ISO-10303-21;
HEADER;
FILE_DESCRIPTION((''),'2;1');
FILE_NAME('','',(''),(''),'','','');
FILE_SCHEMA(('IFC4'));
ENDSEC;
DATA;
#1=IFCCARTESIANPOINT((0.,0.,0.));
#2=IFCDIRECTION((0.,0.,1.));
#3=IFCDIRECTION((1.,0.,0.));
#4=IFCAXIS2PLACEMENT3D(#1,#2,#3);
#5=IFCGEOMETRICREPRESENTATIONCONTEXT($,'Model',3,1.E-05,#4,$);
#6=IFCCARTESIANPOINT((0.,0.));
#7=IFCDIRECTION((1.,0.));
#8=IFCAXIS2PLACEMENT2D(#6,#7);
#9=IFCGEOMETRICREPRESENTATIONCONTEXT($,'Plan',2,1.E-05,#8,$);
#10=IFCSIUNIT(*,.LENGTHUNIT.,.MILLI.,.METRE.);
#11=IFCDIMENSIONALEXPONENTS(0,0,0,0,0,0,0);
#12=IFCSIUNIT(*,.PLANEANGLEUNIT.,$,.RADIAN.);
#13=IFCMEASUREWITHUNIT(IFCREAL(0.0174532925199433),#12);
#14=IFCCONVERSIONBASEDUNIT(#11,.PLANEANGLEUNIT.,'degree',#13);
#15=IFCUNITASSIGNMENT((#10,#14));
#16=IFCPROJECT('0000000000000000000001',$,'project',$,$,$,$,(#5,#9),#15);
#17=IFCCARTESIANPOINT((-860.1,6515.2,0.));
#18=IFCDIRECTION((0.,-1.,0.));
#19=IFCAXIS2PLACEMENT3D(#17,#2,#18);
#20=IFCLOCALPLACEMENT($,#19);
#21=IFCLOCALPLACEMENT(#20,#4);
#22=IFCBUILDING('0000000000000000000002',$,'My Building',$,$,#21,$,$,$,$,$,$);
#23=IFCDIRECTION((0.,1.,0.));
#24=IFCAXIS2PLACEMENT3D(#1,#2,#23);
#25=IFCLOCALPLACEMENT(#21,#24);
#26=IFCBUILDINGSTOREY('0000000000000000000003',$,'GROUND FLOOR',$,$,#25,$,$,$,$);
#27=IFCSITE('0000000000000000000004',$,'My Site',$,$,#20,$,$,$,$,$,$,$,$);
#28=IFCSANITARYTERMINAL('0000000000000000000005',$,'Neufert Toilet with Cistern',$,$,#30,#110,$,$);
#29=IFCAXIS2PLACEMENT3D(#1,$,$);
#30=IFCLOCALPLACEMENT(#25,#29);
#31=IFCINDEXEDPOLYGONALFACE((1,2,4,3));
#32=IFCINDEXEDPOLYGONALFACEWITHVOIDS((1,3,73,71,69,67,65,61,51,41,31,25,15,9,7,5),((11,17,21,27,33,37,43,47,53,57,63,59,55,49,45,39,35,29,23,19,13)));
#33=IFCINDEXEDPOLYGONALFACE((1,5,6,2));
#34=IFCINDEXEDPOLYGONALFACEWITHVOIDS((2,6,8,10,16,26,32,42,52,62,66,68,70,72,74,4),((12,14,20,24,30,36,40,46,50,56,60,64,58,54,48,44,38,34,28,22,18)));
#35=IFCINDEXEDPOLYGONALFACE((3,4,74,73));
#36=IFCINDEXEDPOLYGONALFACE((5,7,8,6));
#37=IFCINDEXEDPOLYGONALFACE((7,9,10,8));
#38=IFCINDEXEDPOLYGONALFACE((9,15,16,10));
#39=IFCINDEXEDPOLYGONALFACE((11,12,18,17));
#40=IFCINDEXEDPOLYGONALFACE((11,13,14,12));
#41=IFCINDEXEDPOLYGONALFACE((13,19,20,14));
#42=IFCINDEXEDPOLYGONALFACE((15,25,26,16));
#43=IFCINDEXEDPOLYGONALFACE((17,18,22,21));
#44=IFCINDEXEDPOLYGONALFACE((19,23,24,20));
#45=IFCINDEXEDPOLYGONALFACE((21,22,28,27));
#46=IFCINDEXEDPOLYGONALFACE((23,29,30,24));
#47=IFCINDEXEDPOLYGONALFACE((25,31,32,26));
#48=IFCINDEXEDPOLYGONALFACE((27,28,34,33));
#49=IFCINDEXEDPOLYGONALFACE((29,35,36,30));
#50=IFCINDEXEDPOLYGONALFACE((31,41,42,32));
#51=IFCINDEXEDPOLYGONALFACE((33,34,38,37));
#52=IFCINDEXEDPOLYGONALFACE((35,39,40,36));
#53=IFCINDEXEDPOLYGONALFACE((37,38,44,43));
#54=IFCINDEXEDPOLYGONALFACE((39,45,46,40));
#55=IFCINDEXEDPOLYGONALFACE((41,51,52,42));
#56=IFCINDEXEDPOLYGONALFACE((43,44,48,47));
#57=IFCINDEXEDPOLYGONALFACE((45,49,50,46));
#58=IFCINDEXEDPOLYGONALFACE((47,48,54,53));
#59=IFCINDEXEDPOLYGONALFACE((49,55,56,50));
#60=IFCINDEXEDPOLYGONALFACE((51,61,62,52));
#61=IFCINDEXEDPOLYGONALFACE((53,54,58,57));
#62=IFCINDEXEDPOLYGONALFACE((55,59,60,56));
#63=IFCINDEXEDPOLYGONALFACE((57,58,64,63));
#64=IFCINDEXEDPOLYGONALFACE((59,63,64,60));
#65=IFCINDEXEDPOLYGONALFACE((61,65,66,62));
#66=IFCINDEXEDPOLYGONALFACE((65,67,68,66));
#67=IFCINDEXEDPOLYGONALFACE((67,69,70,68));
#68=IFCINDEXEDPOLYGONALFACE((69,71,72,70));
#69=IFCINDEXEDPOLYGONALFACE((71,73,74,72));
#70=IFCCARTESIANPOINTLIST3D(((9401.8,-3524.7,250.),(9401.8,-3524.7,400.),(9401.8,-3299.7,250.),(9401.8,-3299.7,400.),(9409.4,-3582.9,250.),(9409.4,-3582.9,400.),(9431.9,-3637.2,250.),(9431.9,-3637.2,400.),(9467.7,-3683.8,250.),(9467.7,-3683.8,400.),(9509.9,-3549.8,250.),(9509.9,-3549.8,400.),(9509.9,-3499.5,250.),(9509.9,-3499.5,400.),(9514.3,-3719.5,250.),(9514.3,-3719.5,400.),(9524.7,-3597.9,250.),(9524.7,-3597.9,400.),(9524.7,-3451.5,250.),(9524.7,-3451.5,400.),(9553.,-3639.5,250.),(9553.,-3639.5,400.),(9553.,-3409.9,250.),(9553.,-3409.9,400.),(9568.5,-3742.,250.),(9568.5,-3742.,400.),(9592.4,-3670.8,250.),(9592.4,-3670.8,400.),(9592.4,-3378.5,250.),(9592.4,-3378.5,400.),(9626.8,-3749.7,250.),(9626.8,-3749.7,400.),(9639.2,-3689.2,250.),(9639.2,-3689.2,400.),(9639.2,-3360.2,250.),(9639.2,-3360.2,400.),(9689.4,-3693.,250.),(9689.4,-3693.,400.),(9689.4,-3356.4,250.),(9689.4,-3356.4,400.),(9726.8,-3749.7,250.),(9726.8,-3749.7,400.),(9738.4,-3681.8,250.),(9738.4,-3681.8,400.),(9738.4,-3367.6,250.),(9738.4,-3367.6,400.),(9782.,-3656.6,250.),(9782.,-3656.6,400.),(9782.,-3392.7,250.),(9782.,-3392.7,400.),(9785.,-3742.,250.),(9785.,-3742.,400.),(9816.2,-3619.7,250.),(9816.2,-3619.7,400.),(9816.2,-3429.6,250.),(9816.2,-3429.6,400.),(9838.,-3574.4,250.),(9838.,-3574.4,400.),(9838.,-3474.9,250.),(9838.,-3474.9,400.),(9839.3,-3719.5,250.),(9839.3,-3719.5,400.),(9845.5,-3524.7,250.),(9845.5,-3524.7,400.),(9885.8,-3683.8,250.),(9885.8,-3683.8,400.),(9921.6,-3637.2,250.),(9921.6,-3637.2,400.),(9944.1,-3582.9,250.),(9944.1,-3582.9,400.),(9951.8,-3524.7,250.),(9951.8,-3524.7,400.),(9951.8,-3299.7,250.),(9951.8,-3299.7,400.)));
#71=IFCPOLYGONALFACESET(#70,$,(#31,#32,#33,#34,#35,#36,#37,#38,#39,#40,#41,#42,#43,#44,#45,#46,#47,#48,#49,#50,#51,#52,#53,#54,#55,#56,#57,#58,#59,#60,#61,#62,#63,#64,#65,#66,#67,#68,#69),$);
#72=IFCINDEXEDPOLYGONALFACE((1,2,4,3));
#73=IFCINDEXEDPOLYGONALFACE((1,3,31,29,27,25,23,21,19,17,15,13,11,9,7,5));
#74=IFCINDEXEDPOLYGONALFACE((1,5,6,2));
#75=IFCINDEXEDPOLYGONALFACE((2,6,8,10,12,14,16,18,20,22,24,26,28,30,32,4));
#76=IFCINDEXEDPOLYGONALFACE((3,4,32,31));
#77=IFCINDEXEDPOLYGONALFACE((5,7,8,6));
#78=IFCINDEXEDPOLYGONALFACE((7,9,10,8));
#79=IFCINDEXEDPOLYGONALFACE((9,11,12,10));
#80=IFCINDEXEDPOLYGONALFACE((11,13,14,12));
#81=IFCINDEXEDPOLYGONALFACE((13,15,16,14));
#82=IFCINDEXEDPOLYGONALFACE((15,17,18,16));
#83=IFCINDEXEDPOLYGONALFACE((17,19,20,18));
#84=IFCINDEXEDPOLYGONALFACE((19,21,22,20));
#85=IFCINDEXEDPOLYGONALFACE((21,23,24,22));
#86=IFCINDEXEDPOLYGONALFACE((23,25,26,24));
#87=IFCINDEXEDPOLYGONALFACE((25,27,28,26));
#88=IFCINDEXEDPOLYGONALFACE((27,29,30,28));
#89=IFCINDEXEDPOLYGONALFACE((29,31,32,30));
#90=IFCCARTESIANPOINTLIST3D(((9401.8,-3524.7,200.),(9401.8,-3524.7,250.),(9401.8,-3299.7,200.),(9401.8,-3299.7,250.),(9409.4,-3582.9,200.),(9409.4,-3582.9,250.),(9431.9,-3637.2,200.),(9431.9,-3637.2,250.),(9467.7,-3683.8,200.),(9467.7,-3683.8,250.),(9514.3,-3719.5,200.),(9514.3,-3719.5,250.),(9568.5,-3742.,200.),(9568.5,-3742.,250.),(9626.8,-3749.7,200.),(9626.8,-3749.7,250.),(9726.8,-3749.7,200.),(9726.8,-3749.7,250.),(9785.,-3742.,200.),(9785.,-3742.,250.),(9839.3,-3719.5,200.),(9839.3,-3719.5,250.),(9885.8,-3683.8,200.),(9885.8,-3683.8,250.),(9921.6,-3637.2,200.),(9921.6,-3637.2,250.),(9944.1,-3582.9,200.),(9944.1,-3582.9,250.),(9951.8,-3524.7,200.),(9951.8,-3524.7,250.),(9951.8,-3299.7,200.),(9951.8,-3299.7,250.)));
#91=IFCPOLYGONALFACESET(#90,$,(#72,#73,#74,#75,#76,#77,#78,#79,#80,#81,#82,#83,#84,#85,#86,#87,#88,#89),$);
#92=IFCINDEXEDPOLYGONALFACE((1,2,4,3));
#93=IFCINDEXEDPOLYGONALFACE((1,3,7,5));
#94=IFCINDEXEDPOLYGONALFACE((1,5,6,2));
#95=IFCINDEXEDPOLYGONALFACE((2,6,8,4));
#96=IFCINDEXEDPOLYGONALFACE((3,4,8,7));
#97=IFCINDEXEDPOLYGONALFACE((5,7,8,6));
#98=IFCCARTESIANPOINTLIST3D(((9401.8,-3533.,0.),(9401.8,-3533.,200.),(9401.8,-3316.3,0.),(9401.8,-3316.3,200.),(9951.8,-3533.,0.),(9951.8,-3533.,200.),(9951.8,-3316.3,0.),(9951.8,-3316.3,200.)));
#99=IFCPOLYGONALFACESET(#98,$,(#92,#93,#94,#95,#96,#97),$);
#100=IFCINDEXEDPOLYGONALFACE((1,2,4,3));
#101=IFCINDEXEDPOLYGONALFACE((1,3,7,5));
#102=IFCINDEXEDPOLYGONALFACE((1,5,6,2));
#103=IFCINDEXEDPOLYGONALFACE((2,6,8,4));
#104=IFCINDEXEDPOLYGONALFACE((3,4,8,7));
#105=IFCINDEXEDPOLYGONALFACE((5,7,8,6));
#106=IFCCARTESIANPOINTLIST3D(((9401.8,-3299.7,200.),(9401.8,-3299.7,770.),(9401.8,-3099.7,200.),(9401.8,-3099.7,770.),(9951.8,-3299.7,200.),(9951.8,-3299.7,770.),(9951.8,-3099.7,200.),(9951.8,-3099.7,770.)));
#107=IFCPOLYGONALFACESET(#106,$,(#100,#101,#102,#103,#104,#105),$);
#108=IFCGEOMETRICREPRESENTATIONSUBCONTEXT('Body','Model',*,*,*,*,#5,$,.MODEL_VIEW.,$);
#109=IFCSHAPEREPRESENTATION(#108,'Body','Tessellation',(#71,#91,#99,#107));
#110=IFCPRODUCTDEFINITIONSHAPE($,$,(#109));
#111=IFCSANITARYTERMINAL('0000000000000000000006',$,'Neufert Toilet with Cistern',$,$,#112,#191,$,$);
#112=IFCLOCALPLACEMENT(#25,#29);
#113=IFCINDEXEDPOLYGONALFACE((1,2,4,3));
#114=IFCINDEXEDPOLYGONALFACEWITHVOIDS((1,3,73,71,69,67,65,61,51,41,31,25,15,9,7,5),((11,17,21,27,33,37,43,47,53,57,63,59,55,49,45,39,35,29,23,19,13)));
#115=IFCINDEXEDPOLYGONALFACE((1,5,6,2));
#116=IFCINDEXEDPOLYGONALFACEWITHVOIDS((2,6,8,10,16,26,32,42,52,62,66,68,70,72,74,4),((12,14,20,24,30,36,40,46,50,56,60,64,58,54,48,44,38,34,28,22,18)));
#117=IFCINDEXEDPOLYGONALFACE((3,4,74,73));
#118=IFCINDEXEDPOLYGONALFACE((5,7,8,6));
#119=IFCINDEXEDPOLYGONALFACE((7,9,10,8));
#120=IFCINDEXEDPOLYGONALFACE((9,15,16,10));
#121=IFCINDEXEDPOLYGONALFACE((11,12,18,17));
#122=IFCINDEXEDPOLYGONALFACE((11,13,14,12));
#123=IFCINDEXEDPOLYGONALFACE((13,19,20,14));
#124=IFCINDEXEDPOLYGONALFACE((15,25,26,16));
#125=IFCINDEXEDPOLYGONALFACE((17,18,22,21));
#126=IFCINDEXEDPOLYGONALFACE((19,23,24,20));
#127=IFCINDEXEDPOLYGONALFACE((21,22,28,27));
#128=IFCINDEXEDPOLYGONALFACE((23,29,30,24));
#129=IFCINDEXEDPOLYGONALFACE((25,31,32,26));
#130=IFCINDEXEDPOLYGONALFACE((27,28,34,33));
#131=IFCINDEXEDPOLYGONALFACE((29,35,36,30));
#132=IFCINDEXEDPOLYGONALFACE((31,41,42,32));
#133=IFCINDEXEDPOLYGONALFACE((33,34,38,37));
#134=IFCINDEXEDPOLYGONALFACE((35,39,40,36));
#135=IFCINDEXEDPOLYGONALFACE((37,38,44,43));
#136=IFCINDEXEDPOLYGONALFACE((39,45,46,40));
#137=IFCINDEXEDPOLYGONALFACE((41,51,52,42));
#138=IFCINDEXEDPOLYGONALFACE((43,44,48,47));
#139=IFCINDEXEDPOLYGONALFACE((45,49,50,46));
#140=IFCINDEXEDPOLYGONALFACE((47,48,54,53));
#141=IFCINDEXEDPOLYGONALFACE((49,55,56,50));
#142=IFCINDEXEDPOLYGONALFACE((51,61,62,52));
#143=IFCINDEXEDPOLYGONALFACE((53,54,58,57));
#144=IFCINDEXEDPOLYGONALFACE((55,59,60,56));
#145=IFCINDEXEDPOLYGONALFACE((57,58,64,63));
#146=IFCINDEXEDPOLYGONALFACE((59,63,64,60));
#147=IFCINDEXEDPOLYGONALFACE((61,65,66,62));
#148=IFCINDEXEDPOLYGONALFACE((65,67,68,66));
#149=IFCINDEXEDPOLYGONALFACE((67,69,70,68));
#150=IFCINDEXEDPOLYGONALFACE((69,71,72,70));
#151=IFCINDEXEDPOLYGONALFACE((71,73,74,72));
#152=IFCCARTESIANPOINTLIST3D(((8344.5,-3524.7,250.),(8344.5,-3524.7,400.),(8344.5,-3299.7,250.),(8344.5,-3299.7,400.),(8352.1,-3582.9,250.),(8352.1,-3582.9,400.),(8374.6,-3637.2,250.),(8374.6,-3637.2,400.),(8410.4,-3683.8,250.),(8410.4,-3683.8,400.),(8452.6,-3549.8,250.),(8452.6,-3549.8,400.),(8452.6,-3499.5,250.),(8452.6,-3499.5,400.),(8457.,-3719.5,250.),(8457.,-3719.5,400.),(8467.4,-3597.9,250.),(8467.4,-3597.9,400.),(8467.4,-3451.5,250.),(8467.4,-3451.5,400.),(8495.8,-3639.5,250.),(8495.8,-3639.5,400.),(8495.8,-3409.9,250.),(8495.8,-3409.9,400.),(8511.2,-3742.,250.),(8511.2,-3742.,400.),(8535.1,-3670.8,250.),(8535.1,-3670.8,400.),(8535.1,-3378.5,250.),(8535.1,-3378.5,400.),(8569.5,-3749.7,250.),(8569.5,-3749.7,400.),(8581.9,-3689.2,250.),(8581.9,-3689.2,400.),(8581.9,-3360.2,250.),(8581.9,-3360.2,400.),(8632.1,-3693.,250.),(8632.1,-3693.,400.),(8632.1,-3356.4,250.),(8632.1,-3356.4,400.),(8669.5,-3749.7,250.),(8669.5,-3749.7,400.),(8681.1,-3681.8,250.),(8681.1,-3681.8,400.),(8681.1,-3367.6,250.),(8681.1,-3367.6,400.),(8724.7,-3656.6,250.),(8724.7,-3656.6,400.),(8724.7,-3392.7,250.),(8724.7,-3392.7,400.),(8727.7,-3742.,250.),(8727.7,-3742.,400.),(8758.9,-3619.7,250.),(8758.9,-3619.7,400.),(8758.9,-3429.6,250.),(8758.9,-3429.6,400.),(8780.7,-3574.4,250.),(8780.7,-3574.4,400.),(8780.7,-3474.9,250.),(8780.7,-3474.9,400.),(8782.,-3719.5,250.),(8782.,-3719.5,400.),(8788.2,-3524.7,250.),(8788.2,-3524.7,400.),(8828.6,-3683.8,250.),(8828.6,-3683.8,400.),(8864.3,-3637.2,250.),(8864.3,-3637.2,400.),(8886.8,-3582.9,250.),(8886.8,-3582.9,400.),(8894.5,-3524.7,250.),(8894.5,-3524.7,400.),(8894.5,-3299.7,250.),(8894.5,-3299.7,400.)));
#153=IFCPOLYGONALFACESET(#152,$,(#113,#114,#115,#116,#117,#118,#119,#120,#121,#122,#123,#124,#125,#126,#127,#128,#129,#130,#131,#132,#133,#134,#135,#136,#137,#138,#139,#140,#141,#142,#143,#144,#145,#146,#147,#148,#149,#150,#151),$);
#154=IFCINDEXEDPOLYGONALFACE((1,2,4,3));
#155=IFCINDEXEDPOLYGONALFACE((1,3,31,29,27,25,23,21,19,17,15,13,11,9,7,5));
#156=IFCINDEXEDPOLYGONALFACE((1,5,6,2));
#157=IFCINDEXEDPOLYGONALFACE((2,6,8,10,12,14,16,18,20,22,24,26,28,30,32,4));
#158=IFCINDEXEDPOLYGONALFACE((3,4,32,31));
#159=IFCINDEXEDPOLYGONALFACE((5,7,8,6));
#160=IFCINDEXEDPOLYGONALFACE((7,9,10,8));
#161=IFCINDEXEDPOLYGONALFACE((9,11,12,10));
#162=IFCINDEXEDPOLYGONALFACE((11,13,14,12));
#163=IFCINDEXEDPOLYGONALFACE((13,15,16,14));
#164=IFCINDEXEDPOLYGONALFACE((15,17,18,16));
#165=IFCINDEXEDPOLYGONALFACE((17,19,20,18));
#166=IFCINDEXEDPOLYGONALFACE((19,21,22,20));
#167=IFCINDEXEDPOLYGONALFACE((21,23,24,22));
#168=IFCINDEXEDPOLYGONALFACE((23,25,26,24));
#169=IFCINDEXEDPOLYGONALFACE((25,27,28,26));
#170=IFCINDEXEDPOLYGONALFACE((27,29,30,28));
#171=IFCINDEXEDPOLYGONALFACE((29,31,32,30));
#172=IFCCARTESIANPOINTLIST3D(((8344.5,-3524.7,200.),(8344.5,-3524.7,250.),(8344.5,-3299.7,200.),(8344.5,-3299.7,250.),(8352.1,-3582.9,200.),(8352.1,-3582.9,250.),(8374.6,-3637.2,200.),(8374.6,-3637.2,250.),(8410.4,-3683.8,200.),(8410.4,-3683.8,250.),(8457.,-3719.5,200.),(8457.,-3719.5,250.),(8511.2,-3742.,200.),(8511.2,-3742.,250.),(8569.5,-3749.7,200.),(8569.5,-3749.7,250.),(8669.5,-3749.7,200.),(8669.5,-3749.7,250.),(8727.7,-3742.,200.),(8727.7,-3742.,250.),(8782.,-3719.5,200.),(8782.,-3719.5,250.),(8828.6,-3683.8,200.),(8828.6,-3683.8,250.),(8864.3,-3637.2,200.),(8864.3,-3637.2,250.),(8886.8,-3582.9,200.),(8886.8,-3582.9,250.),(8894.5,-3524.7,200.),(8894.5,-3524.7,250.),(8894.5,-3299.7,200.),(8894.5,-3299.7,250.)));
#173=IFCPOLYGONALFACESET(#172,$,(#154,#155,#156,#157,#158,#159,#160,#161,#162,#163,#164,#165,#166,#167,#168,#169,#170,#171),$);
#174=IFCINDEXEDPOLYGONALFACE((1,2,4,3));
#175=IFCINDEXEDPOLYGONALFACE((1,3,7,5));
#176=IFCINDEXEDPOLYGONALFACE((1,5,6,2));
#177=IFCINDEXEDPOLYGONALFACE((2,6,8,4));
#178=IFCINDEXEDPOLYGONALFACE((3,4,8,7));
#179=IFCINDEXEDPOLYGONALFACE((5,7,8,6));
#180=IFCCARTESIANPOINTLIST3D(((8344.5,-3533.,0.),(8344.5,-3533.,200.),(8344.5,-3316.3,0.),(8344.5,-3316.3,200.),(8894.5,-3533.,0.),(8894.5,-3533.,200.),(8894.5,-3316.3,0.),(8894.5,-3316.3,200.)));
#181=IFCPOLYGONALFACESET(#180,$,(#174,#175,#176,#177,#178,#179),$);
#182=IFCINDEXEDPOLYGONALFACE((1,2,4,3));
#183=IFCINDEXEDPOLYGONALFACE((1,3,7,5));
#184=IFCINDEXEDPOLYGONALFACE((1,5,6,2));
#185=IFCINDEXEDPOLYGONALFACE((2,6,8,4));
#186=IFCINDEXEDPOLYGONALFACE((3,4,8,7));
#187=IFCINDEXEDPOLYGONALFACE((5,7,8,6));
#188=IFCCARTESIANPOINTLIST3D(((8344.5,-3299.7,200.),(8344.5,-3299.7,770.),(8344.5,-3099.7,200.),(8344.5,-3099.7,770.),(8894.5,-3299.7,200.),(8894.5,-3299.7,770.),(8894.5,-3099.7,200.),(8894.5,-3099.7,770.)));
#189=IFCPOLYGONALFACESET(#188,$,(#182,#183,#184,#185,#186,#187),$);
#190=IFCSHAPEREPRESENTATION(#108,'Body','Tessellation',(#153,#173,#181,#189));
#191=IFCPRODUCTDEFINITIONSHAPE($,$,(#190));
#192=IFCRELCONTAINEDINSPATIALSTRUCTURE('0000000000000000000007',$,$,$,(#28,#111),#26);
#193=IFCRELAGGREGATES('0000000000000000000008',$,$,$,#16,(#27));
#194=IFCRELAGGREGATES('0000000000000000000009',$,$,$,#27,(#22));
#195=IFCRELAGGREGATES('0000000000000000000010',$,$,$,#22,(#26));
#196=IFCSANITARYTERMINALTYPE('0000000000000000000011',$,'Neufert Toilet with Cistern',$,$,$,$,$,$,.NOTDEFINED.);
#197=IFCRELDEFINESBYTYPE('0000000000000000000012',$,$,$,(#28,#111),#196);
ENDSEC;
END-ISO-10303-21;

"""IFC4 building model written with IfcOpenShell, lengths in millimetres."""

from ifc_helpers import new_model, entity, si_unit, converted_unit, frame, frame_2d, origin_with_axes, origin_2d_with_axis, place, context, subcontext, project, spatial, line, arc, indexed_curve, circle_curve, outline, extrude, shape, source, transform, mapped, type_object, type_shapes, element, save


model = new_model("IFC4")

# Units and contexts
model_context = context("Model", 3, precision=1e-05, world=origin_with_axes())
plan_context = context("Plan", 2, precision=1e-05, world=origin_2d_with_axis())
body_context_1 = subcontext(model_context, "Body", "Model", "MODEL_VIEW")
body_context_2 = subcontext(plan_context, "Body", "Plan", "PLAN_VIEW")
ifc_project = project(units=[si_unit("LENGTHUNIT", "METRE", prefix="MILLI"), converted_unit("PLANEANGLEUNIT", "degree", entity("IfcReal", 0.0174532925199433), si_unit("PLANEANGLEUNIT", "RADIAN"), dimensions=[0, 0, 0, 0, 0, 0, 0])], contexts=[model_context, plan_context])

# Site, building, storey
site_placement = place(None, frame((-860.1, 6515.2, 0.0), z_axis=(0.0, 0.0, 1.0), x_axis=(0.0, -1.0, 0.0)))
site = spatial("IfcSite", under=ifc_project, at=site_placement, Name="My Site")
building_placement = place(site_placement, frame((0.0, 0.0, 0.0), z_axis=(0.0, 0.0, 1.0), x_axis=(1.0, 0.0, 0.0)))
building = spatial("IfcBuilding", under=site, at=building_placement, Name="My Building")
storey_placement = place(building_placement, frame((0.0, 0.0, 0.0), z_axis=(0.0, 0.0, 1.0), x_axis=(0.0, 1.0, 0.0)))
storey = spatial("IfcBuildingStorey", under=building, at=storey_placement, Name="GROUND FLOOR")

# Sanitary terminals
sanitary_terminal_type_1 = type_object("IfcSanitaryTerminalType", Name="Neufert Toilet with Cistern", PredefinedType="NOTDEFINED")
shared_shape_1 = source(origin_with_axes(), body_context_1, "Body", "SweptSolid", [
    extrude(outline(indexed_curve([(-275.0, -200.0), (275.0, -200.0), (275.0, -425.0), (209.1, -584.1), (50.0, -650.0), (-50.0, -650.0), (-209.1, -584.1), (-275.0, -425.0)], segments=[line(1, 2), line(2, 3), arc(3, 4, 5), line(5, 6), arc(6, 7, 8), line(8, 1)]), holes=[circle_curve(frame_2d((0.0, -425.0)), 168.8)]), frame((0.0, 0.0, 250.0), z_axis=(0.0, 0.0, 1.0), x_axis=(1.0, 0.0, 0.0)), (0.0, 0.0, 1.0), 150.0),
    extrude(outline(indexed_curve([(-275.0, -200.0), (275.0, -200.0), (275.0, -425.0), (209.1, -584.1), (50.0, -650.0), (-50.0, -650.0), (-209.1, -584.1), (-275.0, -425.0)], segments=[line(1, 2), line(2, 3), arc(3, 4, 5), line(5, 6), arc(6, 7, 8), line(8, 1)])), frame((0.0, 0.0, 200.0), z_axis=(0.0, 0.0, 1.0), x_axis=(1.0, 0.0, 0.0)), (0.0, 0.0, 1.0), 50.0),
    extrude(outline(indexed_curve([(-275.0, -216.7), (275.0, -216.7), (275.0, -433.3), (-275.0, -433.3)], segments=[line(1, 2), line(2, 3), line(3, 4), line(4, 1)])), origin_with_axes(), (0.0, 0.0, 1.0), 200.0),
    extrude(outline(indexed_curve([(-275.0, 0.0), (275.0, 0.0), (275.0, -200.0), (-275.0, -200.0)], segments=[line(1, 2), line(2, 3), line(3, 4), line(4, 1)])), frame((0.0, 0.0, 200.0), z_axis=(0.0, 0.0, 1.0), x_axis=(1.0, 0.0, 0.0)), (0.0, 0.0, 1.0), 570.0),
])
shared_shape_2 = source(origin_with_axes(), body_context_2, "Body", "Curve2D", [
    entity("IfcIndexedPolyCurve", entity("IfcCartesianPointList2D", [[-275.0, 0.0], [275.0, 0.0], [275.0, -200.0], [-275.0, -200.0]]), [entity("IfcLineIndex", [1, 2]), entity("IfcLineIndex", [2, 3]), entity("IfcLineIndex", [3, 4]), entity("IfcLineIndex", [4, 1])]),
    entity("IfcIndexedPolyCurve", entity("IfcCartesianPointList2D", [[165.0, -200.0], [192.5, -335.0]]), [entity("IfcLineIndex", [1, 2])]),
    entity("IfcTrimmedCurve", entity("IfcEllipse", entity("IfcAxis2Placement2D", entity("IfcCartesianPoint", [0.0, -335.0]), entity("IfcDirection", [1.0, 0.0])), 192.5, 315.0), [entity("IfcCartesianPoint", [-192.5, -335.0])], [entity("IfcCartesianPoint", [192.5, -335.0])], True, "CARTESIAN"),
    entity("IfcIndexedPolyCurve", entity("IfcCartesianPointList2D", [[-165.0, -200.0], [-192.5, -335.0]]), [entity("IfcLineIndex", [1, 2])]),
    entity("IfcEllipse", entity("IfcAxis2Placement2D", entity("IfcCartesianPoint", [0.0, -452.0]), entity("IfcDirection", [1.0, 0.0])), 131.2, 157.5),
    entity("IfcIndexedPolyCurve", entity("IfcCartesianPointList2D", [[-34.4, -452.0], [-34.4, -429.5], [34.4, -429.5], [34.4, -452.0]]), [entity("IfcLineIndex", [1, 2]), entity("IfcLineIndex", [2, 3]), entity("IfcLineIndex", [3, 4])]),
    entity("IfcTrimmedCurve", entity("IfcEllipse", entity("IfcAxis2Placement2D", entity("IfcCartesianPoint", [0.0, -452.0]), entity("IfcDirection", [1.0, 0.0])), 34.4, 22.5), [entity("IfcCartesianPoint", [-34.4, -452.0])], [entity("IfcCartesianPoint", [34.4, -452.0])], True, "CARTESIAN"),
])
type_shapes(sanitary_terminal_type_1, [shared_shape_1, shared_shape_2])
for number, where, z_axis, x_axis, name in (
    (1, (9676.8, -3099.7, 0.0), (0.0, 0.0, 1.0), (1.0, 0.0, 0.0), "Neufert Toilet with Cistern"),
    (2, (8619.5, -3099.7, 0.0), (0.0, 0.0, 1.0), (1.0, 0.0, 0.0), "Neufert Toilet with Cistern"),
):
    element("IfcSanitaryTerminal", number, at=place(storey_placement, frame(where, z_axis=z_axis, x_axis=x_axis)), inside=storey, type_object=sanitary_terminal_type_1, Name=name, shapes=[
        shape(body_context_1, "Body", "MappedRepresentation", [mapped(shared_shape_1, transform((0.0, 0.0, 0.0), x_axis=(1.0, 0.0, 0.0), y_axis=(0.0, 1.0, 0.0), z_axis=(0.0, 0.0, 1.0), scale=1.0))]),
        shape(body_context_2, "Body", "MappedRepresentation", [mapped(shared_shape_2, transform((0.0, 0.0, 0.0), x_axis=(1.0, 0.0, 0.0), y_axis=(0.0, 1.0, 0.0), z_axis=(0.0, 0.0, 1.0), scale=1.0))]),
    ])

save(model, "model.ifc")
